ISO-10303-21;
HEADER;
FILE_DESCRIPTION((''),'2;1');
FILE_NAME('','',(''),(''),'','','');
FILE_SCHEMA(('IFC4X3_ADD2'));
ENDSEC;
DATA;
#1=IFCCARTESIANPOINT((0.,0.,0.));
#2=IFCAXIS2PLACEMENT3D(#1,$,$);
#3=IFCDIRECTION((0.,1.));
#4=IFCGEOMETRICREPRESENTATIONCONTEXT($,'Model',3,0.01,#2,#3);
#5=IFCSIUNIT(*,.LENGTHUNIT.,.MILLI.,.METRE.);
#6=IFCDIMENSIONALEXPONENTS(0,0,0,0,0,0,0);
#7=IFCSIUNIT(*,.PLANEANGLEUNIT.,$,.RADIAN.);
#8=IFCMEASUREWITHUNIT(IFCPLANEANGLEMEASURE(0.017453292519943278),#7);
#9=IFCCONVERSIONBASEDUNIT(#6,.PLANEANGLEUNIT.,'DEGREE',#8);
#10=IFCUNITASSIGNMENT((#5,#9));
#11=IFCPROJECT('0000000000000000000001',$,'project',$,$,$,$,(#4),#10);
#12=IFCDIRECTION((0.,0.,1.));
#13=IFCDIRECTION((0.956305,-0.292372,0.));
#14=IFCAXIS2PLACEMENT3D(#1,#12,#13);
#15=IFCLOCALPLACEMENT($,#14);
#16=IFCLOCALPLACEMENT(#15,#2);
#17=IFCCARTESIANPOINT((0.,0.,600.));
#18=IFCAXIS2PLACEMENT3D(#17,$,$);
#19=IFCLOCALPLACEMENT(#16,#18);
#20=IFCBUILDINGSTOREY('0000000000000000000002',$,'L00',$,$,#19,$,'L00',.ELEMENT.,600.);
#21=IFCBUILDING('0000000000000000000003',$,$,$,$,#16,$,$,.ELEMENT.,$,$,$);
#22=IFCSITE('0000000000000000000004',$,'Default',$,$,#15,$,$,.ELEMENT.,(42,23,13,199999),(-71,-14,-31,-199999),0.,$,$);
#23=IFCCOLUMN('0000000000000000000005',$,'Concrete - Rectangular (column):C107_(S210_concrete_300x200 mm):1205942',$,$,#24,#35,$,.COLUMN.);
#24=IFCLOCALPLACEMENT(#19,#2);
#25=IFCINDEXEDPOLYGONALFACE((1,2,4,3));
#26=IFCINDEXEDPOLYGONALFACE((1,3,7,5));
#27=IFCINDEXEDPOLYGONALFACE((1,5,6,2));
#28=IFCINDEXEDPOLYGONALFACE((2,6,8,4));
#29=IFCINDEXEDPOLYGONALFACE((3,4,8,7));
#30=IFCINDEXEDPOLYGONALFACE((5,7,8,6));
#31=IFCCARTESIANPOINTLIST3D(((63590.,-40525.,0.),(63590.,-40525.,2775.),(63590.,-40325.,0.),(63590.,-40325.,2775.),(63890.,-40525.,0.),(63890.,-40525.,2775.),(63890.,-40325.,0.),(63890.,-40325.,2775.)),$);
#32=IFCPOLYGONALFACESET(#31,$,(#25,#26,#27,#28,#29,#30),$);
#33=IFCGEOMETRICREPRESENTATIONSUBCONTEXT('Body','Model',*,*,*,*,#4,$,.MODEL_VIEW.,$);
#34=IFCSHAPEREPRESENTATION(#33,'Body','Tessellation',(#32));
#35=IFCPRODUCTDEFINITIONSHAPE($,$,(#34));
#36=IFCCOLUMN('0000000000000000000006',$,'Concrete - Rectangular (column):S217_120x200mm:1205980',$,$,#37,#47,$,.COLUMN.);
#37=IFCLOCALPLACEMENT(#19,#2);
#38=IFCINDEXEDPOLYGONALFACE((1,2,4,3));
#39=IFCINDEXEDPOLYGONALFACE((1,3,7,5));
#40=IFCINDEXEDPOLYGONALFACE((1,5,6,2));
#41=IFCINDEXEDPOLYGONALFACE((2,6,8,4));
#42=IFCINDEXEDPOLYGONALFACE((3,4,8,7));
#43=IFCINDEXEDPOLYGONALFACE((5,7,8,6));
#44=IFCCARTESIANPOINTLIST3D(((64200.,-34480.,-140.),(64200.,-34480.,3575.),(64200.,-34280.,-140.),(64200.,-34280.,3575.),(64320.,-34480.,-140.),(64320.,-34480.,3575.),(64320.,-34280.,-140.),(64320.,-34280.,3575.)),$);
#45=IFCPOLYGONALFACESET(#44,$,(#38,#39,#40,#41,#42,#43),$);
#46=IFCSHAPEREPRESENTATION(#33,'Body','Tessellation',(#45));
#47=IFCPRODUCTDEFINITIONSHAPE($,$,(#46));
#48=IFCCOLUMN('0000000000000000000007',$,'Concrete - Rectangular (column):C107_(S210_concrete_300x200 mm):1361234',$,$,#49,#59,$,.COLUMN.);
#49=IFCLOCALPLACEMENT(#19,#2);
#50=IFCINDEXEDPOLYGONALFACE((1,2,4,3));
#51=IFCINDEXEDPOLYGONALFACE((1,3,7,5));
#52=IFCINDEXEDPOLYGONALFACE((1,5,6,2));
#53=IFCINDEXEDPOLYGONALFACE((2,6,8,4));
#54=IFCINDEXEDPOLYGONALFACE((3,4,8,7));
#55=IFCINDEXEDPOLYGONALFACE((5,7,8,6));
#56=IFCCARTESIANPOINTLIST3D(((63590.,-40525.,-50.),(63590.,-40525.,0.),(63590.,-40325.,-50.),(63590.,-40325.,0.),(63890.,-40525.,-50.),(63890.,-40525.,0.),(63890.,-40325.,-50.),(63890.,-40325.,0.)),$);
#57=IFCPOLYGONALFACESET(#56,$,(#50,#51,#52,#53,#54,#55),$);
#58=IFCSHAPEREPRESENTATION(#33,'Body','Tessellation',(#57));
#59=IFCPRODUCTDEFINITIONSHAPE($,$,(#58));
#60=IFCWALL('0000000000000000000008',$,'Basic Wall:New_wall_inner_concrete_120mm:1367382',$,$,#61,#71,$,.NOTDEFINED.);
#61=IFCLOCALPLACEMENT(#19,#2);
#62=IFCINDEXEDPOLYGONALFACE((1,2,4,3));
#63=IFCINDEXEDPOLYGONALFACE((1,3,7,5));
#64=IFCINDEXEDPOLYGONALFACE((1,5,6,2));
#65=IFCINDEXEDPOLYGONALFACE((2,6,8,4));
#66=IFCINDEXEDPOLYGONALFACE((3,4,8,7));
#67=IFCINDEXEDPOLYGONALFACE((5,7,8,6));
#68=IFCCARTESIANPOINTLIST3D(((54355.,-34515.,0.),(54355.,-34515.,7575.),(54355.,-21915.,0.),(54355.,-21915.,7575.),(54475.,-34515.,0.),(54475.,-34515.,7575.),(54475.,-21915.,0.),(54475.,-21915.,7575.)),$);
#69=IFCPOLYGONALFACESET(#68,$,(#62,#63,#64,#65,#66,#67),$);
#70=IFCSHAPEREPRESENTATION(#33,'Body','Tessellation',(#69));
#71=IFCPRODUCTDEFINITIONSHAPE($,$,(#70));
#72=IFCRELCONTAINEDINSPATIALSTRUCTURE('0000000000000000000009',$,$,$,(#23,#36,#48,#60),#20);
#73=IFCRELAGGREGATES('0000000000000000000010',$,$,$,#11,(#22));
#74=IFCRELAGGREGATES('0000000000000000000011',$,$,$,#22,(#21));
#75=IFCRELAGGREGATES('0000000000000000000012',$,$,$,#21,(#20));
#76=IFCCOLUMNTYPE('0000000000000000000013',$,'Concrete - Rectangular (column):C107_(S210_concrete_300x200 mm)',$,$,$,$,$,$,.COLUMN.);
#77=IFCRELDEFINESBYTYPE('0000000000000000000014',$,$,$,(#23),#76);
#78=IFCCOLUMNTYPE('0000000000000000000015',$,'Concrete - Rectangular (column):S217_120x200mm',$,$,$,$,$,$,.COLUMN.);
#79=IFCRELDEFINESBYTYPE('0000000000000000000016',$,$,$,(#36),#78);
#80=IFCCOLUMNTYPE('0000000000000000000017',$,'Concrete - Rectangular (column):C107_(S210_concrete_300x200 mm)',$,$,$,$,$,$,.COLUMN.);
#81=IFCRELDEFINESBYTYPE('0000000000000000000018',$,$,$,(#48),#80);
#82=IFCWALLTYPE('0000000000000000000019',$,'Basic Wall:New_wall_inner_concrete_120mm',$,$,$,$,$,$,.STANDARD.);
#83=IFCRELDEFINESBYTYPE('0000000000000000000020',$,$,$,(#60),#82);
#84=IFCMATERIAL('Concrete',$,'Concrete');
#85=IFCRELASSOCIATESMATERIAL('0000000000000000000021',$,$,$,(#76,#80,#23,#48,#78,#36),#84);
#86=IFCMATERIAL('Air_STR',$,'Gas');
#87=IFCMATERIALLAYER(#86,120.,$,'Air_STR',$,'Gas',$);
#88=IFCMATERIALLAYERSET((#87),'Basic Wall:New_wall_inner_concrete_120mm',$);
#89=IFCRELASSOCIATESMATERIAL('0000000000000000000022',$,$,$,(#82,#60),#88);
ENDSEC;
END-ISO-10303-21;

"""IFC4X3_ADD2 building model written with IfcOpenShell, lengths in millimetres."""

from ifc_helpers import new_model, entity, si_unit, converted_unit, direction, frame, frame_2d, origin, origin_2d_with_axis, place, context, subcontext, project, spatial, rectangle, extrude, source, transform, mapped, material, layer, layer_set, material_profile, profile_set, profile_usage, type_object, type_shapes, element, save


model = new_model("IFC4X3_ADD2")

# Units and contexts
model_context = context("Model", 3, precision=0.01, world=origin(), true_north=direction((0.0, 1.0)))
body_context = subcontext(model_context, "Body", "Model", "MODEL_VIEW")
ifc_project = project(units=[si_unit("LENGTHUNIT", "METRE", prefix="MILLI"), converted_unit("PLANEANGLEUNIT", "DEGREE", entity("IfcPlaneAngleMeasure", 0.017453292519943278), si_unit("PLANEANGLEUNIT", "RADIAN"), dimensions=[0, 0, 0, 0, 0, 0, 0])], contexts=[model_context])

# Site, building, storey
site_placement = place(None, frame((0.0, 0.0, 0.0), z_axis=(0.0, 0.0, 1.0), x_axis=(0.956305, -0.292372, 0.0)))
site = spatial("IfcSite", under=ifc_project, at=site_placement, Name="Default", CompositionType="ELEMENT", RefLatitude=(42, 23, 13, 199999), RefLongitude=(-71, -14, -31, -199999), RefElevation=0.0)
building_placement = place(site_placement, origin())
building = spatial("IfcBuilding", under=site, at=building_placement, CompositionType="ELEMENT")
storey_placement = place(building_placement, frame((0.0, 0.0, 600.0)))
storey = spatial("IfcBuildingStorey", under=building, at=storey_placement, Name="L00", LongName="L00", CompositionType="ELEMENT", Elevation=600.0)

# Columns
ifc_material_1 = material(Name="Concrete", Category="Concrete")
ifc_material_profile_1 = material_profile(ifc_material_1, rectangle(XDim=300.0, YDim=200.0, at=frame_2d((0.0, 0.0), x_axis=(1.0, 0.0))), Name="C107_(S210_concrete_300x200 mm)")
ifc_profile_set_1 = profile_set([ifc_material_profile_1], Name="C107_(S210_concrete_300x200 mm)")
ifc_profile_usage_1 = profile_usage(ifc_profile_set_1)
column_type_1 = type_object("IfcColumnType", Name="Concrete - Rectangular (column):C107_(S210_concrete_300x200 mm)", PredefinedType="COLUMN", material=ifc_profile_set_1)
shared_shape_1 = source(origin(), body_context, "Body", "SweptSolid", [
    extrude(rectangle(XDim=300.0, YDim=200.0, at=origin_2d_with_axis()), frame((0.0, 0.0, 600.0), z_axis=(0.0, 0.0, 1.0), x_axis=(-1.0, 0.0, 0.0)), (0.0, 0.0, 1.0), 2775.0),
])
type_shapes(column_type_1, [shared_shape_1])
column_1_placement = place(storey_placement, frame((63740.0, -40425.0, -600.0)))
element("IfcColumn", 1, at=column_1_placement, inside=storey, type_object=column_type_1, material=ifc_profile_usage_1, Name="Concrete - Rectangular (column):C107_(S210_concrete_300x200 mm):1205942", PredefinedType="COLUMN", context=body_context, shape_type="MappedRepresentation", body=[
    mapped(shared_shape_1, transform((0.0, 0.0, 0.0), scale=1.0)),
])
ifc_material_profile_2 = material_profile(ifc_material_1, rectangle(XDim=120.0, YDim=200.0, at=origin_2d_with_axis()), Name="S217_120x200mm")
ifc_profile_set_2 = profile_set([ifc_material_profile_2], Name="S217_120x200mm")
ifc_profile_usage_2 = profile_usage(ifc_profile_set_2)
column_type_2 = type_object("IfcColumnType", Name="Concrete - Rectangular (column):S217_120x200mm", PredefinedType="COLUMN", material=ifc_profile_set_2)
shared_shape_2 = source(origin(), body_context, "Body", "SweptSolid", [
    extrude(rectangle(XDim=120.0, YDim=200.0, at=origin_2d_with_axis()), frame((0.0, 0.0, 460.0), z_axis=(0.0, 0.0, 1.0), x_axis=(-1.0, 0.0, 0.0)), (0.0, 0.0, 1.0), 3715.0),
])
type_shapes(column_type_2, [shared_shape_2])
column_2_placement = place(storey_placement, frame((64260.0, -34380.0, -600.0)))
element("IfcColumn", 2, at=column_2_placement, inside=storey, type_object=column_type_2, material=ifc_profile_usage_2, Name="Concrete - Rectangular (column):S217_120x200mm:1205980", PredefinedType="COLUMN", context=body_context, shape_type="MappedRepresentation", body=[
    mapped(shared_shape_2, transform((0.0, 0.0, 0.0), scale=1.0)),
])
column_type_3 = type_object("IfcColumnType", Name="Concrete - Rectangular (column):C107_(S210_concrete_300x200 mm)", PredefinedType="COLUMN", material=ifc_profile_set_1)
shared_shape_3 = source(origin(), body_context, "Body", "SweptSolid", [
    extrude(rectangle(XDim=300.0, YDim=200.0, at=origin_2d_with_axis()), frame((0.0, 0.0, 550.0), z_axis=(0.0, 0.0, 1.0), x_axis=(-1.0, 0.0, 0.0)), (0.0, 0.0, 1.0), 50.0),
])
type_shapes(column_type_3, [shared_shape_3])
column_3_placement = place(storey_placement, frame((63740.0, -40425.0, -600.0)))
element("IfcColumn", 3, at=column_3_placement, inside=storey, type_object=column_type_3, material=ifc_profile_usage_1, Name="Concrete - Rectangular (column):C107_(S210_concrete_300x200 mm):1361234", PredefinedType="COLUMN", context=body_context, shape_type="MappedRepresentation", body=[
    mapped(shared_shape_3, transform((0.0, 0.0, 0.0), scale=1.0)),
])

# Wall
ifc_material_2 = material(Name="Air_STR", Category="Gas")
ifc_layer = layer(ifc_material_2, 120.0, Name="Air_STR", Category="Gas")
ifc_layer_set = layer_set([ifc_layer], Name="Basic Wall:New_wall_inner_concrete_120mm")
wall_type = type_object("IfcWallType", Name="Basic Wall:New_wall_inner_concrete_120mm", PredefinedType="STANDARD", material=ifc_layer_set)
wall_placement = place(storey_placement, frame((54415.0, -34515.0, 0.0), z_axis=(0.0, 0.0, 1.0), x_axis=(0.0, 1.0, 0.0)))
element("IfcWall", 4, at=wall_placement, inside=storey, type_object=wall_type, material=ifc_layer_set, Name="Basic Wall:New_wall_inner_concrete_120mm:1367382", PredefinedType="NOTDEFINED", context=body_context, shape_type="SweptSolid", body=[
    extrude(rectangle(XDim=12600.0, YDim=120.0, at=frame_2d((6300.0, 0.0), x_axis=(-1.0, 0.0))), origin(), (0.0, 0.0, 1.0), 7575.0),
])

save(model, "model.ifc")
